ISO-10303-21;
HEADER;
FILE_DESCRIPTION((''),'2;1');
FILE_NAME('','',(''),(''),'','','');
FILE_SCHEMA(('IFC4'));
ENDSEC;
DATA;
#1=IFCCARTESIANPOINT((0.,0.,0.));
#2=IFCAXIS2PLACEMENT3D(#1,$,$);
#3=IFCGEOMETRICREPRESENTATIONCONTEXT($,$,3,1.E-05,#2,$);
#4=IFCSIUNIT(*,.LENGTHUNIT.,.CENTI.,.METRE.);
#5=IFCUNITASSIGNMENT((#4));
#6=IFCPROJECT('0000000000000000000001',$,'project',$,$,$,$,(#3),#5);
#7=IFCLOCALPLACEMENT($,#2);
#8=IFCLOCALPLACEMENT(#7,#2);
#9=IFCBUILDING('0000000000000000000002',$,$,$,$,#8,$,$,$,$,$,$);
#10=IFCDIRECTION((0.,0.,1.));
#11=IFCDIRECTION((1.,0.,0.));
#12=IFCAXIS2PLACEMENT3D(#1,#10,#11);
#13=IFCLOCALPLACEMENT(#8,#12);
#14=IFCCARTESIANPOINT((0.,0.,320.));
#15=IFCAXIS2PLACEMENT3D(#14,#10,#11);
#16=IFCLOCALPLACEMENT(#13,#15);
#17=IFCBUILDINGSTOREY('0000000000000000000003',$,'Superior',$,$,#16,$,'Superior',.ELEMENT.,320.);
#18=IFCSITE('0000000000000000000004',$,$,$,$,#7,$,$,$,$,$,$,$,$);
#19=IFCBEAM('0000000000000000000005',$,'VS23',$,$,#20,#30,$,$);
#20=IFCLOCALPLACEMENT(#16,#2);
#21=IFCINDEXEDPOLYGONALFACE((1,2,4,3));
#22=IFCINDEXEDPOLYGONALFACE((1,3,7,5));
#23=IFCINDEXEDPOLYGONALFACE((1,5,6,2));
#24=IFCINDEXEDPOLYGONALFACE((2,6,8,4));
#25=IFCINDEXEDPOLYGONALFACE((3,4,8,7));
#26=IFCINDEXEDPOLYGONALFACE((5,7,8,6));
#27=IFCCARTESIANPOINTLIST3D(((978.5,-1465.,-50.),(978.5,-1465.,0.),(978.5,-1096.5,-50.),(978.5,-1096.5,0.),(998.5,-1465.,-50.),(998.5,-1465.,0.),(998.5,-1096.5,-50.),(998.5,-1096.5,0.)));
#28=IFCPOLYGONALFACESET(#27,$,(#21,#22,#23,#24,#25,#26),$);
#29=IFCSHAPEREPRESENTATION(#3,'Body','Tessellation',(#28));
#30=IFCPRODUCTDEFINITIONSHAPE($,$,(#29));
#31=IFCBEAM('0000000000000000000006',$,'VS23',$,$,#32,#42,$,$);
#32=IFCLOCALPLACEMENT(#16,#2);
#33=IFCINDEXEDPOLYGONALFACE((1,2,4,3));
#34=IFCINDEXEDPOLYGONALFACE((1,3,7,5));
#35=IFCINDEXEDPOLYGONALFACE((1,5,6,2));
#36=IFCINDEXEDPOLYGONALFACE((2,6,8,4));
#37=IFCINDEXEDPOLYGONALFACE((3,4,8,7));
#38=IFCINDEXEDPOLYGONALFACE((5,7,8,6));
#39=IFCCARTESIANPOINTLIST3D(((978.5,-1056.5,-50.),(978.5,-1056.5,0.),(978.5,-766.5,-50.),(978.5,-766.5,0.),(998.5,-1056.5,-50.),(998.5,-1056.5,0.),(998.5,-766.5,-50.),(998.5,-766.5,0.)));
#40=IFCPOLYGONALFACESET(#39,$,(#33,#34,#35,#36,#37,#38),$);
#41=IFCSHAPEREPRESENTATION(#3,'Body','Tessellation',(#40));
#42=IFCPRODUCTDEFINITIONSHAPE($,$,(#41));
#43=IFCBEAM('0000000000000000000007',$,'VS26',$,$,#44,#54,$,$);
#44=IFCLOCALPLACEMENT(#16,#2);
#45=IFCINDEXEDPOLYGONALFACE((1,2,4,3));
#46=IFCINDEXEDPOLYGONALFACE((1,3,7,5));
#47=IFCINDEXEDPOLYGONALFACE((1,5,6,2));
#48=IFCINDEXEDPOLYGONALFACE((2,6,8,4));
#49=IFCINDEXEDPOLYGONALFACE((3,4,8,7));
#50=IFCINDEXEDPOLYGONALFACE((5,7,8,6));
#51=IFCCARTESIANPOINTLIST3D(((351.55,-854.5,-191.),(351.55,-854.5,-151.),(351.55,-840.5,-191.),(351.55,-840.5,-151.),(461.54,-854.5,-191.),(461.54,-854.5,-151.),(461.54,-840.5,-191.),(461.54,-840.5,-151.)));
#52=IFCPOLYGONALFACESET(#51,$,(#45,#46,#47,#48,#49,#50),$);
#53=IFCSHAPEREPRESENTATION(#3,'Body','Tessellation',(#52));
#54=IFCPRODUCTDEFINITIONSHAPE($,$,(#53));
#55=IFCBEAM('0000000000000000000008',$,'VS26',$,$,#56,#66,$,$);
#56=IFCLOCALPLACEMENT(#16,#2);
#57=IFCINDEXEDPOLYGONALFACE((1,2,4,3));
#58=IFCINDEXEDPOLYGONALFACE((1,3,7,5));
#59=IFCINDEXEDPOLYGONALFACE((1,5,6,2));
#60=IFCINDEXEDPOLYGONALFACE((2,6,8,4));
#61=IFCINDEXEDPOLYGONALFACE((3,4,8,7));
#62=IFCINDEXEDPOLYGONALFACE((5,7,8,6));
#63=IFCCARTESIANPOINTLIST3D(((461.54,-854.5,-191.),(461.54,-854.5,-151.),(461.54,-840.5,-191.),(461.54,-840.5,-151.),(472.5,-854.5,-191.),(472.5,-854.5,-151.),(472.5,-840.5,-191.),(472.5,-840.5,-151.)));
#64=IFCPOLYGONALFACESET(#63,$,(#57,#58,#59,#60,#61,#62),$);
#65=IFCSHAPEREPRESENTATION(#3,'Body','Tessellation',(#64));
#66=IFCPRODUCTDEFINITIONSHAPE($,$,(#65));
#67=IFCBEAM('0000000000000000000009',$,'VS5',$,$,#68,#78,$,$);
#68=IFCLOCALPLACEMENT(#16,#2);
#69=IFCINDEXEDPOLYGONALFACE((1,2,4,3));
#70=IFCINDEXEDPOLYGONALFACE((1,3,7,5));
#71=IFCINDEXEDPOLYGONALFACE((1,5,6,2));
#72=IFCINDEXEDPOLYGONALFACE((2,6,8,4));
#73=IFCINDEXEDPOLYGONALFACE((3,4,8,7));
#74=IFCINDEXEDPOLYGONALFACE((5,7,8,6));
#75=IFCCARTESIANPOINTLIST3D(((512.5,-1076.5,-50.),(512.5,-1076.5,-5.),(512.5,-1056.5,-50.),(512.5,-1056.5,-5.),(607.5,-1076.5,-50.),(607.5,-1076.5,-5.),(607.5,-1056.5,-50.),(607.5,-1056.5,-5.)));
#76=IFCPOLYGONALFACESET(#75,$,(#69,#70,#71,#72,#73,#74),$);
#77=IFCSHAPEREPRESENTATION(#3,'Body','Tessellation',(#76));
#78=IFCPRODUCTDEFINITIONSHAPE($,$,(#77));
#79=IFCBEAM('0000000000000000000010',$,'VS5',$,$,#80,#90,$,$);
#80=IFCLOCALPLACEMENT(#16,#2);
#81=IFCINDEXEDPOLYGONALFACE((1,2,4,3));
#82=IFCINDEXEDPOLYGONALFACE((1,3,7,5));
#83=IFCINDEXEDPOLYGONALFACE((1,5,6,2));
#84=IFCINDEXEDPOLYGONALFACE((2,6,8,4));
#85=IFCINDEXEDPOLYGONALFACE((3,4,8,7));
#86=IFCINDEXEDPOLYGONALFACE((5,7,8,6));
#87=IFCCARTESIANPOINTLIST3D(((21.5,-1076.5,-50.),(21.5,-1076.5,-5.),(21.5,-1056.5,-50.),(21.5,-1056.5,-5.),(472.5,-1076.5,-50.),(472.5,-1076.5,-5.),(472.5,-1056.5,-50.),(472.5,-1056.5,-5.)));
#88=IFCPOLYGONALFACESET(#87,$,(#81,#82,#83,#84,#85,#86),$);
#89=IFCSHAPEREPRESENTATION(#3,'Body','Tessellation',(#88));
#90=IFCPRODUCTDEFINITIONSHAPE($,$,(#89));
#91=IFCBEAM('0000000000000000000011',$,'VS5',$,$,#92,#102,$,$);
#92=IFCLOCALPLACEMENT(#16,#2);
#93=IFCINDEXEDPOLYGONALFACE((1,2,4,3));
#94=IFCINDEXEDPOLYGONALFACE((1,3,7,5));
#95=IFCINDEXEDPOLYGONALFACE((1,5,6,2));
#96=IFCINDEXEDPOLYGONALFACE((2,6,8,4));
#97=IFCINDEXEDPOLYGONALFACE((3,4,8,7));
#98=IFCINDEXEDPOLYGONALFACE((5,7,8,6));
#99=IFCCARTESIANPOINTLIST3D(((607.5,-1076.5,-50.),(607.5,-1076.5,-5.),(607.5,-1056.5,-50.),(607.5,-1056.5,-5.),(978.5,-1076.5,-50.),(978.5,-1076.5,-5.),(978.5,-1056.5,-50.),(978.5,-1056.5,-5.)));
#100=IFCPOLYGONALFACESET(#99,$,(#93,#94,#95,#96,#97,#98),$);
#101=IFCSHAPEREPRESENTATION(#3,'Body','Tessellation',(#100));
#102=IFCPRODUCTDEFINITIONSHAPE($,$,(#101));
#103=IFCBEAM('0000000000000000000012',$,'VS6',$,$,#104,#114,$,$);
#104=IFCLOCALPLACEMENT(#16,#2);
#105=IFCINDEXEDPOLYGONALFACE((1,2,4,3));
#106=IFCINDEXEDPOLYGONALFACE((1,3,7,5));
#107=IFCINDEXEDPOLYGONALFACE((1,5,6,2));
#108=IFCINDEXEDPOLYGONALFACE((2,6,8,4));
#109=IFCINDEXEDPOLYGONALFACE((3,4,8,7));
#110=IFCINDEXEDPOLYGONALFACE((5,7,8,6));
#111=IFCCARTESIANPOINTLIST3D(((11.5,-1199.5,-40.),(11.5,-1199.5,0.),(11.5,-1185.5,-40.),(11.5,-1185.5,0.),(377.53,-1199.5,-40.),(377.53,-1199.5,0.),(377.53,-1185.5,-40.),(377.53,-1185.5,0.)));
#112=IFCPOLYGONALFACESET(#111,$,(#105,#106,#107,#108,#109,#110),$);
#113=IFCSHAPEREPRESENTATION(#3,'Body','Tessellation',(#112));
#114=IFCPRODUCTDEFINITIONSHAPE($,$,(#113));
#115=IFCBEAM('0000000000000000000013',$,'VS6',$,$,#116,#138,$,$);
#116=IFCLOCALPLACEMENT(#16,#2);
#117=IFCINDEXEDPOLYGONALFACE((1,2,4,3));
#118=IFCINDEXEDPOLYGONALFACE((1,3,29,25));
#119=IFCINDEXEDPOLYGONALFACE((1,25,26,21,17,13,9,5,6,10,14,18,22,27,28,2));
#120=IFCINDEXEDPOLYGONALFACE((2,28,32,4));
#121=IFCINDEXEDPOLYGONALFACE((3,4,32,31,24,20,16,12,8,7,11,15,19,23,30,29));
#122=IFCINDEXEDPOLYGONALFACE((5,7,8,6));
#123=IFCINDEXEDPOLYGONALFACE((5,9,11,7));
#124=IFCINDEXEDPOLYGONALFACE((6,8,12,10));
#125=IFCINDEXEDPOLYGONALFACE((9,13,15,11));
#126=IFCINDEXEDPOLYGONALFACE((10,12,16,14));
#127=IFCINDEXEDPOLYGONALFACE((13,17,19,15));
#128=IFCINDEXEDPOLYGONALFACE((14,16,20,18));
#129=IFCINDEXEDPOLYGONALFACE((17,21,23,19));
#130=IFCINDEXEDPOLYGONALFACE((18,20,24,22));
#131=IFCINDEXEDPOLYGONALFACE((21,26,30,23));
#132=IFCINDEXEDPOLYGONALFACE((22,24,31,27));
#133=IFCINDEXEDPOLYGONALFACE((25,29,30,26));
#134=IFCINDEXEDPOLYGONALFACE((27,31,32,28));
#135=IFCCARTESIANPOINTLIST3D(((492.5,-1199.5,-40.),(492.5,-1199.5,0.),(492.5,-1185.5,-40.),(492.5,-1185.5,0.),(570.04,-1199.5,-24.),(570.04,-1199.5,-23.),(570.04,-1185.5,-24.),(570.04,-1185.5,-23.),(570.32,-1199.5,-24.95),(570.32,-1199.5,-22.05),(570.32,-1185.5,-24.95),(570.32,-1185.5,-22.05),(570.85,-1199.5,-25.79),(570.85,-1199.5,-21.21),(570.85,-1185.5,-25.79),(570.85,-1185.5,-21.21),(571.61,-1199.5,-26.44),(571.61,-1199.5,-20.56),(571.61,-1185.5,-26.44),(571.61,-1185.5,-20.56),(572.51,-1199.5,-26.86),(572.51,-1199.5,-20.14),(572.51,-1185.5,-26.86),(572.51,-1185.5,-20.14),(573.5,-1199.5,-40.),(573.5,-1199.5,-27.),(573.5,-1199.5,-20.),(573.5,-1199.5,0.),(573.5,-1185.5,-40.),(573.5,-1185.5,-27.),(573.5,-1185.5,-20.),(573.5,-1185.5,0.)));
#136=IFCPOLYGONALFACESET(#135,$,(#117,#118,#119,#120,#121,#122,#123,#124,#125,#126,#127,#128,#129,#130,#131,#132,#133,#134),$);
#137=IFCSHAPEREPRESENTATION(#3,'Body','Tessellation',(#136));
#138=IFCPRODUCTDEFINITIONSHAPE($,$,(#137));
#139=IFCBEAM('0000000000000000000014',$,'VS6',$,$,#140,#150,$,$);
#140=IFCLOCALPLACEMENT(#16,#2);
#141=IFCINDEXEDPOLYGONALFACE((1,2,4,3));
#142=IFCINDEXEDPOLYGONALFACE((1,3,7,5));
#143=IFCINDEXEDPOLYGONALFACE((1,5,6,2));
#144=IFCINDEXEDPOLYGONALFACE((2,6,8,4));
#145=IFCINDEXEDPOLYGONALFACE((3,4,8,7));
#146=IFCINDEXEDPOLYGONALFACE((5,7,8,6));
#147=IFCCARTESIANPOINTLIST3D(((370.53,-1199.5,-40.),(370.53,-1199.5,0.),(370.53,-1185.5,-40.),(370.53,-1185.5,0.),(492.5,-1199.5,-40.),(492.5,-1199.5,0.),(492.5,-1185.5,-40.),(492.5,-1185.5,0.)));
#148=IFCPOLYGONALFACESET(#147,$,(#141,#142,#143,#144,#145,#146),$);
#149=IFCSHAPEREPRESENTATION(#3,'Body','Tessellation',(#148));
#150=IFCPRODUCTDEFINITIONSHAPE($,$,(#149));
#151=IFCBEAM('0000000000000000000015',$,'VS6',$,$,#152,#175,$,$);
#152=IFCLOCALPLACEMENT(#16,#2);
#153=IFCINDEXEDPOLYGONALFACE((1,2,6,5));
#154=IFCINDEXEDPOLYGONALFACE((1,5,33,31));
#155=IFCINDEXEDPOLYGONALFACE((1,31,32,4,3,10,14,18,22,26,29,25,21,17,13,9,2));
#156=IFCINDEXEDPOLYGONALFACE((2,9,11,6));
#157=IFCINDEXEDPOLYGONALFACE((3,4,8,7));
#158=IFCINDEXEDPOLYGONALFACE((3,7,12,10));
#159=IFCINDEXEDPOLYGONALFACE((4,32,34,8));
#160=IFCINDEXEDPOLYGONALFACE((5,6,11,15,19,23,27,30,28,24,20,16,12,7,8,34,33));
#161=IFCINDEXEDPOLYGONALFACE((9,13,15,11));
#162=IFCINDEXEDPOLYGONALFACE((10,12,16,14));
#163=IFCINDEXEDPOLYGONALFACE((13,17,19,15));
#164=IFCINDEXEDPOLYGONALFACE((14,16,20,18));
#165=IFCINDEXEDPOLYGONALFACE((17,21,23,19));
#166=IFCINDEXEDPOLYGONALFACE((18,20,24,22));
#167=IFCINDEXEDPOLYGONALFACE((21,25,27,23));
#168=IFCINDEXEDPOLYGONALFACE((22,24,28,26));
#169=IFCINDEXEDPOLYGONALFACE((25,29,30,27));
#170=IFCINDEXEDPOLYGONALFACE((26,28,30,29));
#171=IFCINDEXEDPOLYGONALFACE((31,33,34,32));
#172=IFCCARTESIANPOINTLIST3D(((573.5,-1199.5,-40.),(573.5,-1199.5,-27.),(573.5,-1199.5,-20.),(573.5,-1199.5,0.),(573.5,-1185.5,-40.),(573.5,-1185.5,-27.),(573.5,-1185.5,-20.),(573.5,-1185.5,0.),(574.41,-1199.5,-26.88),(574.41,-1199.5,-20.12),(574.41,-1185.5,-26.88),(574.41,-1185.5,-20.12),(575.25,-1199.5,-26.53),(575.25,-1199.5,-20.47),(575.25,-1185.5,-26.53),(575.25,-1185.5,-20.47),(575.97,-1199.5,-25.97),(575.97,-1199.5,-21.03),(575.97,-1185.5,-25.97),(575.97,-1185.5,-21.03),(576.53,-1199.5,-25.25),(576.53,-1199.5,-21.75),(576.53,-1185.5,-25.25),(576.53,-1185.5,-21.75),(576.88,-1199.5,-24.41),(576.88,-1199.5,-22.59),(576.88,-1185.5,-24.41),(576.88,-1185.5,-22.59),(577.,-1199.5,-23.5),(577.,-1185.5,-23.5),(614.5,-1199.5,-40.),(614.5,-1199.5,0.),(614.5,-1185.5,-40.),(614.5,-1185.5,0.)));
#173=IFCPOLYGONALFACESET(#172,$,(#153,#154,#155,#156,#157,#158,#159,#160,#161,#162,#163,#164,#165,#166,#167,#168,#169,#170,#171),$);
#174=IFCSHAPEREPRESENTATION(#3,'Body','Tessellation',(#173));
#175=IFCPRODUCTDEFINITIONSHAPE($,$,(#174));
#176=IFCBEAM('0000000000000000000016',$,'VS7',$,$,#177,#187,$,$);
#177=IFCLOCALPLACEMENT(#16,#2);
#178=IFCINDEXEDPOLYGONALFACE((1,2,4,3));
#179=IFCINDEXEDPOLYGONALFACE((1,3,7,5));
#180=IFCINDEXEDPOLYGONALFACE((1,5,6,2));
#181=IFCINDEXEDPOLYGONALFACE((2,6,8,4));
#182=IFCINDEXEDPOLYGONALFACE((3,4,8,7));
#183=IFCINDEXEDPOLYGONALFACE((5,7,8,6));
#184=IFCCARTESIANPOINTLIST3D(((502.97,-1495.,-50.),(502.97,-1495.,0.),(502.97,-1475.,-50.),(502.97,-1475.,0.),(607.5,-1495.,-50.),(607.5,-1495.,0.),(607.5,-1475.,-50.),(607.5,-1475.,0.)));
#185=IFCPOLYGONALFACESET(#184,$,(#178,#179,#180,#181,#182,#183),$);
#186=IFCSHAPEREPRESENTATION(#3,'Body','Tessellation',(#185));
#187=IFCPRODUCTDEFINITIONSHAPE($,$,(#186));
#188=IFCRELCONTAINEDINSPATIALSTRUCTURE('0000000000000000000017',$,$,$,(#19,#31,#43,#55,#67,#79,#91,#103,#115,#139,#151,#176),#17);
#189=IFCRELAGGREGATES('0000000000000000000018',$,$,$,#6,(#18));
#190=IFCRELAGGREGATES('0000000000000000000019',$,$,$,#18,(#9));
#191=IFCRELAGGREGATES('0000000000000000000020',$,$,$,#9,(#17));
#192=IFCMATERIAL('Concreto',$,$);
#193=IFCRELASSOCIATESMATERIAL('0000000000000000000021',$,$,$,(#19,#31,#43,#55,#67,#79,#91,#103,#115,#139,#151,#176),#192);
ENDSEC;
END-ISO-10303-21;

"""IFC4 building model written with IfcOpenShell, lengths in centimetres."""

from ifc_helpers import new_model, si_unit, frame, origin, origin_with_axes, origin_2d_with_axis, place, context, project, spatial, polyline, circle, outline, extrude, material, element, save


model = new_model("IFC4")

# Units and contexts
context_of_model = context(None, 3, precision=1e-05, world=origin())
ifc_project = project(units=[si_unit("LENGTHUNIT", "METRE", prefix="CENTI")], contexts=[context_of_model])

# Site, building, storey
site_placement = place(None, origin())
site = spatial("IfcSite", under=ifc_project, at=site_placement)
building_placement = place(site_placement, origin())
building = spatial("IfcBuilding", under=site, at=building_placement)
placement = place(building_placement, origin_with_axes())
storey_placement = place(placement, frame((0.0, 0.0, 320.0), z_axis=(0.0, 0.0, 1.0), x_axis=(1.0, 0.0, 0.0)))
storey = spatial("IfcBuildingStorey", under=building, at=storey_placement, Name="Superior", LongName="Superior", CompositionType="ELEMENT", Elevation=320.0)

# Shared definitions
ifc_material = material(Name="Concreto")

# Beams
beam_1_placement = place(storey_placement, frame((988.5, -1280.75, 0.0), z_axis=(0.0, 0.0, 1.0), x_axis=(1.0, 0.0, 0.0)))
element("IfcBeam", 1, at=beam_1_placement, inside=storey, material=ifc_material, Name="VS23", context=context_of_model, shape_type="SolidModel", body=[
    extrude(outline(polyline([(-10.0, -25.0), (10.0, -25.0), (10.0, 25.0), (-10.0, 25.0), (-10.0, -25.0)])), frame((0.0, -184.25, -25.0), z_axis=(0.0, 1.0, 0.0), x_axis=(1.0, 0.0, 0.0)), (0.0, 0.0, 1.0), 368.5),
])
beam_2_placement = place(storey_placement, frame((988.5, -911.5, 0.0), z_axis=(0.0, 0.0, 1.0), x_axis=(1.0, 0.0, 0.0)))
element("IfcBeam", 2, at=beam_2_placement, inside=storey, material=ifc_material, Name="VS23", context=context_of_model, shape_type="SolidModel", body=[
    extrude(outline(polyline([(-10.0, -25.0), (10.0, -25.0), (10.0, 25.0), (-10.0, 25.0), (-10.0, -25.0)])), frame((0.0, -145.0, -25.0), z_axis=(0.0, 1.0, 0.0), x_axis=(1.0, 0.0, 0.0)), (0.0, 0.0, 1.0), 290.0),
])
beam_3_placement = place(storey_placement, frame((406.55, -847.5, -151.0), z_axis=(0.0, 0.0, 1.0), x_axis=(1.0, 0.0, 0.0)))
element("IfcBeam", 3, at=beam_3_placement, inside=storey, material=ifc_material, Name="VS26", context=context_of_model, shape_type="SolidModel", body=[
    extrude(outline(polyline([(-7.0, -20.0), (7.0, -20.0), (7.0, 20.0), (-7.0, 20.0), (-7.0, -20.0)])), frame((-54.99, 0.0, -20.0), z_axis=(1.0, 0.0, 0.0), x_axis=(0.0, -1.0, 0.0)), (0.0, 0.0, 1.0), 109.99),
])
beam_4_placement = place(storey_placement, frame((467.02, -847.5, -151.0), z_axis=(0.0, 0.0, 1.0), x_axis=(1.0, 0.0, 0.0)))
element("IfcBeam", 4, at=beam_4_placement, inside=storey, material=ifc_material, Name="VS26", context=context_of_model, shape_type="SolidModel", body=[
    extrude(outline(polyline([(-7.0, -20.0), (7.0, -20.0), (7.0, 20.0), (-7.0, 20.0), (-7.0, -20.0)])), frame((-5.48, 0.0, -20.0), z_axis=(1.0, 0.0, 0.0), x_axis=(0.0, -1.0, 0.0)), (0.0, 0.0, 1.0), 10.96),
])
beam_5_placement = place(storey_placement, frame((560.0, -1066.5, -5.0), z_axis=(0.0, 0.0, 1.0), x_axis=(1.0, 0.0, 0.0)))
element("IfcBeam", 5, at=beam_5_placement, inside=storey, material=ifc_material, Name="VS5", context=context_of_model, shape_type="SolidModel", body=[
    extrude(outline(polyline([(-10.0, -22.5), (10.0, -22.5), (10.0, 22.5), (-10.0, 22.5), (-10.0, -22.5)])), frame((-47.5, 0.0, -22.5), z_axis=(1.0, 0.0, 0.0), x_axis=(0.0, -1.0, 0.0)), (0.0, 0.0, 1.0), 95.0),
])
beam_6_placement = place(storey_placement, frame((247.0, -1066.5, -5.0), z_axis=(0.0, 0.0, 1.0), x_axis=(1.0, 0.0, 0.0)))
element("IfcBeam", 6, at=beam_6_placement, inside=storey, material=ifc_material, Name="VS5", context=context_of_model, shape_type="SolidModel", body=[
    extrude(outline(polyline([(-10.0, -22.5), (10.0, -22.5), (10.0, 22.5), (-10.0, 22.5), (-10.0, -22.5)])), frame((-225.5, 0.0, -22.5), z_axis=(1.0, 0.0, 0.0), x_axis=(0.0, -1.0, 0.0)), (0.0, 0.0, 1.0), 451.0),
])
beam_7_placement = place(storey_placement, frame((793.0, -1066.5, -5.0), z_axis=(0.0, 0.0, 1.0), x_axis=(1.0, 0.0, 0.0)))
element("IfcBeam", 7, at=beam_7_placement, inside=storey, material=ifc_material, Name="VS5", context=context_of_model, shape_type="SolidModel", body=[
    extrude(outline(polyline([(-10.0, -22.5), (10.0, -22.5), (10.0, 22.5), (-10.0, 22.5), (-10.0, -22.5)])), frame((-185.5, 0.0, -22.5), z_axis=(1.0, 0.0, 0.0), x_axis=(0.0, -1.0, 0.0)), (0.0, 0.0, 1.0), 371.0),
])
beam_8_placement = place(storey_placement, frame((194.51, -1192.5, 0.0), z_axis=(0.0, 0.0, 1.0), x_axis=(1.0, 0.0, 0.0)))
element("IfcBeam", 8, at=beam_8_placement, inside=storey, material=ifc_material, Name="VS6", context=context_of_model, shape_type="SolidModel", body=[
    extrude(outline(polyline([(7.0, 20.0), (-7.0, 20.0), (-7.0, -20.0), (7.0, -20.0), (7.0, 20.0)])), frame((183.01, 0.0, -20.0), z_axis=(-1.0, 0.0, 0.0), x_axis=(0.0, -1.0, 0.0)), (0.0, 0.0, 1.0), 366.03),
])

# Beam, opening
beam_9_placement = place(storey_placement, frame((533.0, -1192.5, 0.0), z_axis=(0.0, 0.0, 1.0), x_axis=(1.0, 0.0, 0.0)))
beam_9 = element("IfcBeam", 9, at=beam_9_placement, inside=storey, material=ifc_material, Name="VS6", context=context_of_model, shape_type="SolidModel", body=[
    extrude(outline(polyline([(7.0, 20.0), (-7.0, 20.0), (-7.0, -20.0), (7.0, -20.0), (7.0, 20.0)])), frame((40.5, 0.0, -20.0), z_axis=(-1.0, 0.0, 0.0), x_axis=(0.0, -1.0, 0.0)), (0.0, 0.0, 1.0), 81.0),
])
opening_1_placement = place(storey_placement, frame((0.0, 0.0, -320.0), z_axis=(0.0, 0.0, 1.0), x_axis=(1.0, 0.0, 0.0)))
element("IfcOpeningElement", 10, at=opening_1_placement, cuts=beam_9, material=ifc_material, context=context_of_model, shape_type="SweptSolid", body=[
    extrude(circle(Radius=3.5, at=origin_2d_with_axis()), frame((573.5, -1185.5, 296.5), z_axis=(0.0, -1.0, 0.0), x_axis=(1.0, 0.0, 0.0)), (0.0, 0.0, 1.0), 14.0),
])

# Beam
beam_10_placement = place(storey_placement, frame((431.51, -1192.5, 0.0), z_axis=(0.0, 0.0, 1.0), x_axis=(1.0, 0.0, 0.0)))
element("IfcBeam", 11, at=beam_10_placement, inside=storey, material=ifc_material, Name="VS6", context=context_of_model, shape_type="SolidModel", body=[
    extrude(outline(polyline([(7.0, 20.0), (-7.0, 20.0), (-7.0, -20.0), (7.0, -20.0), (7.0, 20.0)])), frame((60.98, 0.0, -20.0), z_axis=(-1.0, 0.0, 0.0), x_axis=(0.0, -1.0, 0.0)), (0.0, 0.0, 1.0), 121.97),
])

# Beam, opening
beam_11_placement = place(storey_placement, frame((594.0, -1192.5, 0.0), z_axis=(0.0, 0.0, 1.0), x_axis=(1.0, 0.0, 0.0)))
beam_11 = element("IfcBeam", 12, at=beam_11_placement, inside=storey, material=ifc_material, Name="VS6", context=context_of_model, shape_type="SolidModel", body=[
    extrude(outline(polyline([(7.0, 20.0), (-7.0, 20.0), (-7.0, -20.0), (7.0, -20.0), (7.0, 20.0)])), frame((20.5, 0.0, -20.0), z_axis=(-1.0, 0.0, 0.0), x_axis=(0.0, -1.0, 0.0)), (0.0, 0.0, 1.0), 41.0),
])
opening_2_placement = place(storey_placement, frame((0.0, 0.0, -320.0), z_axis=(0.0, 0.0, 1.0), x_axis=(1.0, 0.0, 0.0)))
element("IfcOpeningElement", 13, at=opening_2_placement, cuts=beam_11, material=ifc_material, context=context_of_model, shape_type="SweptSolid", body=[
    extrude(circle(Radius=3.5, at=origin_2d_with_axis()), frame((573.5, -1185.5, 296.5), z_axis=(0.0, -1.0, 0.0), x_axis=(1.0, 0.0, 0.0)), (0.0, 0.0, 1.0), 14.0),
])

# Beam
beam_12_placement = place(storey_placement, frame((555.24, -1485.0, 0.0), z_axis=(0.0, 0.0, 1.0), x_axis=(1.0, 0.0, 0.0)))
element("IfcBeam", 14, at=beam_12_placement, inside=storey, material=ifc_material, Name="VS7", context=context_of_model, shape_type="SolidModel", body=[
    extrude(outline(polyline([(-10.0, -25.0), (10.0, -25.0), (10.0, 25.0), (-10.0, 25.0), (-10.0, -25.0)])), frame((-52.27, 0.0, -25.0), z_axis=(1.0, 0.0, 0.0), x_axis=(0.0, -1.0, 0.0)), (0.0, 0.0, 1.0), 104.53),
])

save(model, "model.ifc")
